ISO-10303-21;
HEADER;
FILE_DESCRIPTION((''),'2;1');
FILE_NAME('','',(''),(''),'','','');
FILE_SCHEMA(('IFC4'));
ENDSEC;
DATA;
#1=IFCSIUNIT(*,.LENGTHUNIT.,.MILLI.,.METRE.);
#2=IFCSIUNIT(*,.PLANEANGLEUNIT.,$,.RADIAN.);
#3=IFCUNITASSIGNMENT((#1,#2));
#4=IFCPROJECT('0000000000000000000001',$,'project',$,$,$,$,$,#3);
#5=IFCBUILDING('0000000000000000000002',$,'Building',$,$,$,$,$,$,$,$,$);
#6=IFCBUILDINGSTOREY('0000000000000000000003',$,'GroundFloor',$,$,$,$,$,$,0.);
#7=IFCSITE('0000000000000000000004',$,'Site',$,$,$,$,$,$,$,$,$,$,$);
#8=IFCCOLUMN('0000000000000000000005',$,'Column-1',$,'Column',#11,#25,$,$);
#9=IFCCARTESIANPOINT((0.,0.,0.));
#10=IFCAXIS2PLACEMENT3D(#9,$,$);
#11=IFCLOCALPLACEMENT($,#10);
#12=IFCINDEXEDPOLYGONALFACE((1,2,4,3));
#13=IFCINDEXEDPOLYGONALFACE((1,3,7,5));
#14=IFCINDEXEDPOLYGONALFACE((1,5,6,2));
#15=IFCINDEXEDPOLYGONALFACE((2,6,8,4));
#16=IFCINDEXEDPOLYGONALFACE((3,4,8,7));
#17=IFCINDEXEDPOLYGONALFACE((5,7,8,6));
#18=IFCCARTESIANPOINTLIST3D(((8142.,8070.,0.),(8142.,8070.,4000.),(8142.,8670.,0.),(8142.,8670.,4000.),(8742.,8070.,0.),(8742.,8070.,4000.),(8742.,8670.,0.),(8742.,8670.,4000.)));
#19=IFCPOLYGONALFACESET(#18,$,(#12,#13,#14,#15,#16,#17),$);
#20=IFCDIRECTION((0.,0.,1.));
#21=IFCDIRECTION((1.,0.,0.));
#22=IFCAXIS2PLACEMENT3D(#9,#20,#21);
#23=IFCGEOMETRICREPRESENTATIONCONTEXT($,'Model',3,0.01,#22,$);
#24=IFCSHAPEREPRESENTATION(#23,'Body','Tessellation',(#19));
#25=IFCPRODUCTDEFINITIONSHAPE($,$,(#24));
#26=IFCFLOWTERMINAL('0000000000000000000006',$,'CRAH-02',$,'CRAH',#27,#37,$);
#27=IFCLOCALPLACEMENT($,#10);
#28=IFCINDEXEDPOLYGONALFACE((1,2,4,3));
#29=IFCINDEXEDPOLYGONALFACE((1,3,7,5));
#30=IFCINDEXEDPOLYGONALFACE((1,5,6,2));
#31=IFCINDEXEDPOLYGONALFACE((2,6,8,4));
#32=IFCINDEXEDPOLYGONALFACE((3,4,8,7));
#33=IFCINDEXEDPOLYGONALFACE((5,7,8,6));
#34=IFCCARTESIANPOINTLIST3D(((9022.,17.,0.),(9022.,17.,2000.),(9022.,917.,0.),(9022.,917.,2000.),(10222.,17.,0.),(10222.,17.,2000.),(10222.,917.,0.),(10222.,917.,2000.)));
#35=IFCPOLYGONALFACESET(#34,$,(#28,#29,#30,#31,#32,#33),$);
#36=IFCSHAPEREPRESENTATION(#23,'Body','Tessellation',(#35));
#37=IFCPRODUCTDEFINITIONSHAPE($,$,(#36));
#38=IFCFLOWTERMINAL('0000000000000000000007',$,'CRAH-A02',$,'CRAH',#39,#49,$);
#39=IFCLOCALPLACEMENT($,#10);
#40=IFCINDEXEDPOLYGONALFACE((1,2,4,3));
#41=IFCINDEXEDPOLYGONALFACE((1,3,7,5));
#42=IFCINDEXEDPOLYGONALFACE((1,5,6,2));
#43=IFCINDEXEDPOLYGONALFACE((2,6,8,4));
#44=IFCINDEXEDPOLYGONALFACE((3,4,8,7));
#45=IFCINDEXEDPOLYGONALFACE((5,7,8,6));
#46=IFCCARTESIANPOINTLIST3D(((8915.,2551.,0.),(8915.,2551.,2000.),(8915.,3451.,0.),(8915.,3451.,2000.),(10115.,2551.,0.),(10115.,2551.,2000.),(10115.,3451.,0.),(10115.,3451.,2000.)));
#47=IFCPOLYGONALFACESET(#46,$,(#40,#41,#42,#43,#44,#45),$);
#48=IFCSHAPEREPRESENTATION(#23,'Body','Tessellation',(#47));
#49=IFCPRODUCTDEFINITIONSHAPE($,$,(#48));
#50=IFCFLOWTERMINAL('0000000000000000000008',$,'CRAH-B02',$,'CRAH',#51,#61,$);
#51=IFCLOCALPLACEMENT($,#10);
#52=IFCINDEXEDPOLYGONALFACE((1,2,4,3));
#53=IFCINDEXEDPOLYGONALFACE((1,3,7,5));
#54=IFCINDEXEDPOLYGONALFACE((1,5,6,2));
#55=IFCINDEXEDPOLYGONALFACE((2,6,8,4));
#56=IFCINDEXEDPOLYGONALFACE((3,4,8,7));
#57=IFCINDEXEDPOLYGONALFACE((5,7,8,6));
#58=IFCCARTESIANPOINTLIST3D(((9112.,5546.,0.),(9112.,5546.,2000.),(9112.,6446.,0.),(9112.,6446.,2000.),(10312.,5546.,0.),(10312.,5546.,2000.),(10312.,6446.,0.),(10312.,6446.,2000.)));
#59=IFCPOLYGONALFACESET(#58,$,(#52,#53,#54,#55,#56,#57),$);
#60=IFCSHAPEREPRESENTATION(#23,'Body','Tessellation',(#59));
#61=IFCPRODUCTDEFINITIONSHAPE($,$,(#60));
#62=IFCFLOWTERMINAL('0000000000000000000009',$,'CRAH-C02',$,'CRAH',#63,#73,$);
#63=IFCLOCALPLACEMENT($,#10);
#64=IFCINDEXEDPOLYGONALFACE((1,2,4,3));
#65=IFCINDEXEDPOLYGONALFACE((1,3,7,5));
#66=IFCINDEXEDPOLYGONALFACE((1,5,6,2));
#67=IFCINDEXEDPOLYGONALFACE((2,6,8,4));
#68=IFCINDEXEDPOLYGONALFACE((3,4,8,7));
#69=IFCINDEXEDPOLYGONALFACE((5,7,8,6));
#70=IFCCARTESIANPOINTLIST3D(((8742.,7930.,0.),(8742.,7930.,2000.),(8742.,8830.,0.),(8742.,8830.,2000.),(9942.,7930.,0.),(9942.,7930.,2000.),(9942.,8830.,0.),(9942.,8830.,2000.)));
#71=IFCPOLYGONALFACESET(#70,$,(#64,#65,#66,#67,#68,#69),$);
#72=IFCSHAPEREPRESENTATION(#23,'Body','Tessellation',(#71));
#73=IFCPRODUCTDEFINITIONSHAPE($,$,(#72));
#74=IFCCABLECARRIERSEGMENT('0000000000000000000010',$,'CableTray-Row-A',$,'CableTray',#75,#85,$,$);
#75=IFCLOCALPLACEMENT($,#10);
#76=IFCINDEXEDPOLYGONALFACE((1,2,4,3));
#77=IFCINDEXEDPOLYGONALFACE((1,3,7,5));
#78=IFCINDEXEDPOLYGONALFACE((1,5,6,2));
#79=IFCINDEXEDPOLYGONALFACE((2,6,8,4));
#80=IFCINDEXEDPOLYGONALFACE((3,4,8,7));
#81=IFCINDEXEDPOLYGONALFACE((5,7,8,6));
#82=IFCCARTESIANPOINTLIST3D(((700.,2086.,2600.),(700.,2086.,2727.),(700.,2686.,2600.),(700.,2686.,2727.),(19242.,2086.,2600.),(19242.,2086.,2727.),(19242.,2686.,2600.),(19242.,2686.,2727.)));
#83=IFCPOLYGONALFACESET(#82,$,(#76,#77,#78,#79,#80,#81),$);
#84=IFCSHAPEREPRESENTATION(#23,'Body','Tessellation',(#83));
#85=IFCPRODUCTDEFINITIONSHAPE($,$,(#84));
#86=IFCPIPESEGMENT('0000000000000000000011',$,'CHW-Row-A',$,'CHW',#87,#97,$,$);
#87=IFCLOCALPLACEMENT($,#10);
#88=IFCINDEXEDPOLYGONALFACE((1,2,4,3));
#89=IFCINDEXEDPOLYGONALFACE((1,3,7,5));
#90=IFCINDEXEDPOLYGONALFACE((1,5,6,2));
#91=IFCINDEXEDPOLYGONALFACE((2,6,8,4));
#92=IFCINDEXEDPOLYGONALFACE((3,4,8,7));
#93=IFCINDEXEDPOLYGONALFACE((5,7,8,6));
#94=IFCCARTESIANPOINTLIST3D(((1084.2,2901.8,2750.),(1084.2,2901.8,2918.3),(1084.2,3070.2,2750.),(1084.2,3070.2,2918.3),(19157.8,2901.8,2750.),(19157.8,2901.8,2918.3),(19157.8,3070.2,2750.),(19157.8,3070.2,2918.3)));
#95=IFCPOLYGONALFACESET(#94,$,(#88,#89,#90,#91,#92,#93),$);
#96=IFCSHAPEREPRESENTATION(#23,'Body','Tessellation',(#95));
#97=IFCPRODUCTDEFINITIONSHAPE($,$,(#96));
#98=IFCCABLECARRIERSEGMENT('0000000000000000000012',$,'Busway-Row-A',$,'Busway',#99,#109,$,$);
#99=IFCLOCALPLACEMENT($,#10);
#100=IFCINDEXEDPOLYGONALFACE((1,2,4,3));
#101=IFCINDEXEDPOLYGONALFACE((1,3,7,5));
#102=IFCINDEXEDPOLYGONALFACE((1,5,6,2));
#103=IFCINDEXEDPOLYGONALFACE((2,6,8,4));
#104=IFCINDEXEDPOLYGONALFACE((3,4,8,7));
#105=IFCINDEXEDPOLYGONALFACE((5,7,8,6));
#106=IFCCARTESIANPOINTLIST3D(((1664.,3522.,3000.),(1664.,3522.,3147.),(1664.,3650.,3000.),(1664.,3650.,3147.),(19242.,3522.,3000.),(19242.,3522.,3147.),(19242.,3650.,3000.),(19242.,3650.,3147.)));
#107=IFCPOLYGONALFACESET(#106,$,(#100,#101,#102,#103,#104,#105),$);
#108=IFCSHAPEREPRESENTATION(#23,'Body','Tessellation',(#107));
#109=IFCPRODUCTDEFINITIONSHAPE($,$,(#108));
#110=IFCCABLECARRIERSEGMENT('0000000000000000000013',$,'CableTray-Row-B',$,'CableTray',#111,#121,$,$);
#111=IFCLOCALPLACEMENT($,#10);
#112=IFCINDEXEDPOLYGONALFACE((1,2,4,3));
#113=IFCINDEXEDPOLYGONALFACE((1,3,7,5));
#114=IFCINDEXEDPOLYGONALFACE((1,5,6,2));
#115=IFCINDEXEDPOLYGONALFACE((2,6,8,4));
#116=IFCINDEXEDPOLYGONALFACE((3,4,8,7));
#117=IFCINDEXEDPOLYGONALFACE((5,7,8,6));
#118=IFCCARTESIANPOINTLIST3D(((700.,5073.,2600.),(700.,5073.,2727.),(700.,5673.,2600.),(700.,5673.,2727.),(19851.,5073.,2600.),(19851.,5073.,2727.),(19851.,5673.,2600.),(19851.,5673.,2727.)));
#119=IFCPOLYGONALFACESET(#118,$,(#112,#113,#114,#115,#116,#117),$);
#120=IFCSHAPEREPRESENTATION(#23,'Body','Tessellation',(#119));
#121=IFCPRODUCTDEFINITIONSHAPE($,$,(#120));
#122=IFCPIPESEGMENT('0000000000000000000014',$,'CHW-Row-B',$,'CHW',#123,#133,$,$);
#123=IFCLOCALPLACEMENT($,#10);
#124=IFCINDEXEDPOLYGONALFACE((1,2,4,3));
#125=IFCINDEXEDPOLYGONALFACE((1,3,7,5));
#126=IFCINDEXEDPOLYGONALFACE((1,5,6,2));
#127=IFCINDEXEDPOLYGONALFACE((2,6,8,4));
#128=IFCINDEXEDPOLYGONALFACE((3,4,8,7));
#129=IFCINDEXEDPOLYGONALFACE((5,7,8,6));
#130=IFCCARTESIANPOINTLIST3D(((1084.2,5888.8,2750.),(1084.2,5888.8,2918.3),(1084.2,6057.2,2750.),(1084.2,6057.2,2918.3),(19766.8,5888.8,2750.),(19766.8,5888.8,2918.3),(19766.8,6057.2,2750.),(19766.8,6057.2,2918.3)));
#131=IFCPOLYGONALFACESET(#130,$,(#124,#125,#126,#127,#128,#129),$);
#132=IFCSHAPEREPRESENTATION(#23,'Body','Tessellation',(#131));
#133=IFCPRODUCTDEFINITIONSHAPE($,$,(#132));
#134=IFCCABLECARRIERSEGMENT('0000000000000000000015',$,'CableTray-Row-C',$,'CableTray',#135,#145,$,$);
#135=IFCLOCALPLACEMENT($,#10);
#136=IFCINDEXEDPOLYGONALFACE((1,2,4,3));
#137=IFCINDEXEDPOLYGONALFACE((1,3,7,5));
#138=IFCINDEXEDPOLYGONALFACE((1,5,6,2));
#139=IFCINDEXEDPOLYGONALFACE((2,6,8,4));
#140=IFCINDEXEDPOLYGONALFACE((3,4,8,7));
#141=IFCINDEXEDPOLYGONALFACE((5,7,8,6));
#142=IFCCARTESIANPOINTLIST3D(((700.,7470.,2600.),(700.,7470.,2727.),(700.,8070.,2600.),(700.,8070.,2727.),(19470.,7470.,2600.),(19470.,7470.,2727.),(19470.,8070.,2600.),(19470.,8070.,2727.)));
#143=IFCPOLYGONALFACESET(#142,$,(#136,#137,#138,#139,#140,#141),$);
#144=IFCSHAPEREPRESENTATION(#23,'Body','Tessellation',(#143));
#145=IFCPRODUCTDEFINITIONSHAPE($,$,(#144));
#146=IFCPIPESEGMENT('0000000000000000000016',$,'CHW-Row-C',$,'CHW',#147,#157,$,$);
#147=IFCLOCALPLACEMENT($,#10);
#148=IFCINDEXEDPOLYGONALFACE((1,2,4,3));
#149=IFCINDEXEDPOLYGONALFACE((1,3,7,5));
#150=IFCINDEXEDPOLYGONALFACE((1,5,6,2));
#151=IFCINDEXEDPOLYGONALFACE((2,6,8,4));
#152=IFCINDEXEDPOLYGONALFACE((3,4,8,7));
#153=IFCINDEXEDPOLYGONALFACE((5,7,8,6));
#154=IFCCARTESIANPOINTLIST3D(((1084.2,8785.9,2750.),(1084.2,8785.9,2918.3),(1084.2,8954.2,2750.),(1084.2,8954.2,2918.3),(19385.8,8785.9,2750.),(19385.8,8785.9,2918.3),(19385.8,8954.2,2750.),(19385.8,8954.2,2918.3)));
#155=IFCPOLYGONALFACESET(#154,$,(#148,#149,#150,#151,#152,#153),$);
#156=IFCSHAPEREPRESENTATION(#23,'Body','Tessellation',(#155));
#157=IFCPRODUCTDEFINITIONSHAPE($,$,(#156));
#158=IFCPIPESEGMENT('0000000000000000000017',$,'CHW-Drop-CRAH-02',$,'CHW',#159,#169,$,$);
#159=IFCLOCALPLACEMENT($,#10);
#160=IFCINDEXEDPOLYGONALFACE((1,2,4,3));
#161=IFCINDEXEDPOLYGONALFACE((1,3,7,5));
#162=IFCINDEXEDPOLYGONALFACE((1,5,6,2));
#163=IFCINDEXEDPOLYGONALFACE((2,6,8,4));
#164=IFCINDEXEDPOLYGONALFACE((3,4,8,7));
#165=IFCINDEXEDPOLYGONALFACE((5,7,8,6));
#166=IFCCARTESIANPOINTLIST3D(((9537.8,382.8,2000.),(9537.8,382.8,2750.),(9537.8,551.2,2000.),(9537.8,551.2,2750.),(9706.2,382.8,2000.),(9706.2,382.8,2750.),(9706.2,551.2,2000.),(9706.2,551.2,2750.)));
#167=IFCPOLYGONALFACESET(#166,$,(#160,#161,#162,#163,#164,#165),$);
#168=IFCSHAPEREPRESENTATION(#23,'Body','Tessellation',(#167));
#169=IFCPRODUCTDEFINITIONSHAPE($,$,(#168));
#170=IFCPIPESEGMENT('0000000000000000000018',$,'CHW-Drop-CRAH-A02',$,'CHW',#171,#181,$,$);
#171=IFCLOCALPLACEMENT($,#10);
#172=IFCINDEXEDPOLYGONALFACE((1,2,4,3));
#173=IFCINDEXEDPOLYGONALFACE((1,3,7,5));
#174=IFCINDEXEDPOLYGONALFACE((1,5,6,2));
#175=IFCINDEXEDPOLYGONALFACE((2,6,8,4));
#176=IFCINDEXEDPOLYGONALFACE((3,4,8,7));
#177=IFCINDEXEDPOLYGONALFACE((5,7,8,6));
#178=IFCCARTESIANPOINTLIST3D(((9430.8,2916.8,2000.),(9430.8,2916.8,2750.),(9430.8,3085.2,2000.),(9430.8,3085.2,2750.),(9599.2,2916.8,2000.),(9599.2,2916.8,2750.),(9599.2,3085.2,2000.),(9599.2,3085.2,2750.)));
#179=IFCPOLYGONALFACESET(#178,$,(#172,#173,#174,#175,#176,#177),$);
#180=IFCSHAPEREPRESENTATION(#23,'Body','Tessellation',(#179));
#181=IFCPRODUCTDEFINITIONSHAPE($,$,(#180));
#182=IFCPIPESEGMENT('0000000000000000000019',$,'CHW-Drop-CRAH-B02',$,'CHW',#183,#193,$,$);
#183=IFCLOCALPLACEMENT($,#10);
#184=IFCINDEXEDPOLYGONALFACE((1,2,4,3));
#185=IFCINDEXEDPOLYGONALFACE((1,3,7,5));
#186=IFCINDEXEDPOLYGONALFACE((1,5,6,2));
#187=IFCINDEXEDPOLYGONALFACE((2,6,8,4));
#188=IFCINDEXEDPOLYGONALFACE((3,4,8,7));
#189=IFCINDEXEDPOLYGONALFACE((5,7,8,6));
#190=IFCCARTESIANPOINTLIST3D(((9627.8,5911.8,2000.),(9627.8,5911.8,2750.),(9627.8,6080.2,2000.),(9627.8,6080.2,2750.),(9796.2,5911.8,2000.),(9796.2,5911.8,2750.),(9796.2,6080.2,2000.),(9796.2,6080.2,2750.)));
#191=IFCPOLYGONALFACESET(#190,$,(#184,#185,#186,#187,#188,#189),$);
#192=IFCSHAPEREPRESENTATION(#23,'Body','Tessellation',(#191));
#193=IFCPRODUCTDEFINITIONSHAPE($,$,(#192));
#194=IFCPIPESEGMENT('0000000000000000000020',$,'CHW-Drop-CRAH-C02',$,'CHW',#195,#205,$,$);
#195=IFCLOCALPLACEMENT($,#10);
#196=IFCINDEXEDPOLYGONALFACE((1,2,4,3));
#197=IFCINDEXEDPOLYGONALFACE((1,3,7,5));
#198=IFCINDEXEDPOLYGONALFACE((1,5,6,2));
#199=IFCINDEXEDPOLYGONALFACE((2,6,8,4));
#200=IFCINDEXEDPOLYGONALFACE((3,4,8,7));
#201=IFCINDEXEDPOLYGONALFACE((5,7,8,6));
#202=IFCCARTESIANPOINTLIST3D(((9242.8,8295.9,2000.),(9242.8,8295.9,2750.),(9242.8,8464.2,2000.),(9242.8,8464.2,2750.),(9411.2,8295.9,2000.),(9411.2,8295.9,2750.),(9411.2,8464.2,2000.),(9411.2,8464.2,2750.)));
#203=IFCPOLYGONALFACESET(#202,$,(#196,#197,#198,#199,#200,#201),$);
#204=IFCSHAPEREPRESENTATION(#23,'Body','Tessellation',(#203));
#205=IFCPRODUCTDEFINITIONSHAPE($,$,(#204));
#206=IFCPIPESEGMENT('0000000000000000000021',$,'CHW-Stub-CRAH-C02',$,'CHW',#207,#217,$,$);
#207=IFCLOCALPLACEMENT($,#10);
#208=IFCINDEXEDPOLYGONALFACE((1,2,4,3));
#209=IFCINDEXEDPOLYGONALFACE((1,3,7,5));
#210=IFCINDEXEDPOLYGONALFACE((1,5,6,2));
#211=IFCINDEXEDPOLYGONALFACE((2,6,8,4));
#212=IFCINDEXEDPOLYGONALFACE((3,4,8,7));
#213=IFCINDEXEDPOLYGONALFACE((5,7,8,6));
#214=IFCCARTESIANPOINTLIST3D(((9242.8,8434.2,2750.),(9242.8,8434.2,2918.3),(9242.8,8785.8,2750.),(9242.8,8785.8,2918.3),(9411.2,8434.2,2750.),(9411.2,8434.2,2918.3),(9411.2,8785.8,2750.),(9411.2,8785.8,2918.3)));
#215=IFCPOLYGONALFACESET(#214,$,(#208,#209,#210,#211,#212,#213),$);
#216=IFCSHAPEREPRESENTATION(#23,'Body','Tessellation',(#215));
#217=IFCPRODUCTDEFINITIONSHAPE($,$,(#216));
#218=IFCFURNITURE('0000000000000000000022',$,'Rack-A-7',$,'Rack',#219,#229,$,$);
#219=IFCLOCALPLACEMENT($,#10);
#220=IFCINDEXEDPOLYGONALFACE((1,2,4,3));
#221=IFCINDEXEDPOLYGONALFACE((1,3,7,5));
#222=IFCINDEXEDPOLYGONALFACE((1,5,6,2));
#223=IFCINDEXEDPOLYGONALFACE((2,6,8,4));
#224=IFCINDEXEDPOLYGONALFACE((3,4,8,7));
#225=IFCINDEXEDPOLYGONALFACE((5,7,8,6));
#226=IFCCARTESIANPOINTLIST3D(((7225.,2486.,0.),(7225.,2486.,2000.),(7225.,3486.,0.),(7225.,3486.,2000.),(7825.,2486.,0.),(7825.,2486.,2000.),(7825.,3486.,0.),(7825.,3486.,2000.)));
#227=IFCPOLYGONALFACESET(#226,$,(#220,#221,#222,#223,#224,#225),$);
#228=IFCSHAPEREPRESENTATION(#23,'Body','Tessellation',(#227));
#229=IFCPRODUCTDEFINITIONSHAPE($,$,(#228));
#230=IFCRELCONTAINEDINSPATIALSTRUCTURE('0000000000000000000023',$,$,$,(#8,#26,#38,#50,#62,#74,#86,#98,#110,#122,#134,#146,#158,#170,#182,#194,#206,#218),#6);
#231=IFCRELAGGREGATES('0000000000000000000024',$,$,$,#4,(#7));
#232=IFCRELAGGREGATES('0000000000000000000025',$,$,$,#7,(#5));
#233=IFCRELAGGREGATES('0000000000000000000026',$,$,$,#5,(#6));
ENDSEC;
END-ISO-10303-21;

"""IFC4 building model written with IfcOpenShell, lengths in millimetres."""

from ifc_helpers import new_model, si_unit, frame, origin, origin_with_axes, origin_2d, place, context, project, spatial, rectangle, extrude, element, save


model = new_model("IFC4")

# Units and contexts
model_context = context("Model", 3, precision=0.01, world=origin_with_axes())
ifc_project = project(units=[si_unit("LENGTHUNIT", "METRE", prefix="MILLI"), si_unit("PLANEANGLEUNIT", "RADIAN")])

# Site, building, storey
site = spatial("IfcSite", under=ifc_project, Name="Site")
building = spatial("IfcBuilding", under=site, Name="Building")
storey = spatial("IfcBuildingStorey", under=building, Name="GroundFloor", Elevation=0.0)

# Column
column_placement = place(None, frame((8442.0, 8370.0, 0.0), z_axis=(0.0, 0.0, 1.0), x_axis=(1.0, 0.0, 0.0)))
element("IfcColumn", 1, at=column_placement, inside=storey, Name="Column-1", ObjectType="Column", context=model_context, shape_type="SweptSolid", body=[
    extrude(rectangle(XDim=600.0, YDim=600.0, at=origin_2d()), origin(), (0.0, 0.0, 1.0), 4000.0),
])

# Flow terminals
for number, where, z_axis, x_axis, name in (
    (2, (9622.0, 467.0, 0.0), (0.0, 0.0, 1.0), (1.0, 0.0, 0.0), "CRAH-02"),
    (3, (9515.0, 3001.0, 0.0), (0.0, 0.0, 1.0), (1.0, 0.0, 0.0), "CRAH-A02"),
    (4, (9712.0, 5996.0, 0.0), (0.0, 0.0, 1.0), (1.0, 0.0, 0.0), "CRAH-B02"),
    (5, (9342.0, 8380.0, 0.0), (0.0, 0.0, 1.0), (1.0, 0.0, 0.0), "CRAH-C02"),
):
    element("IfcFlowTerminal", number, at=place(None, frame(where, z_axis=z_axis, x_axis=x_axis)), inside=storey, Name=name, ObjectType="CRAH", context=model_context, shape_type="SweptSolid", body=[
        extrude(rectangle(XDim=1200.0, YDim=900.0, at=origin_2d()), origin(), (0.0, 0.0, 1.0), 2000.0),
    ])

# Cable carrier segment
cable_carrier_segment_1_placement = place(None, frame((9971.0, 2386.0, 2600.0), z_axis=(0.0, 0.0, 1.0), x_axis=(1.0, 0.0, 0.0)))
element("IfcCableCarrierSegment", 6, at=cable_carrier_segment_1_placement, inside=storey, Name="CableTray-Row-A", ObjectType="CableTray", context=model_context, shape_type="SweptSolid", body=[
    extrude(rectangle(XDim=18542.0, YDim=600.0, at=origin_2d()), origin(), (0.0, 0.0, 1.0), 127.0),
])

# Pipe segment
pipe_segment_1_placement = place(None, frame((10121.0, 2986.0, 2750.0), z_axis=(0.0, 0.0, 1.0), x_axis=(1.0, 0.0, 0.0)))
element("IfcPipeSegment", 7, at=pipe_segment_1_placement, inside=storey, Name="CHW-Row-A", ObjectType="CHW", context=model_context, shape_type="SweptSolid", body=[
    extrude(rectangle(XDim=18073.7, YDim=168.3, at=origin_2d()), origin(), (0.0, 0.0, 1.0), 168.3),
])

# Cable carrier segments
cable_carrier_segment_2_placement = place(None, frame((10453.0, 3586.0, 3000.0), z_axis=(0.0, 0.0, 1.0), x_axis=(1.0, 0.0, 0.0)))
element("IfcCableCarrierSegment", 8, at=cable_carrier_segment_2_placement, inside=storey, Name="Busway-Row-A", ObjectType="Busway", context=model_context, shape_type="SweptSolid", body=[
    extrude(rectangle(XDim=17578.0, YDim=128.0, at=origin_2d()), origin(), (0.0, 0.0, 1.0), 147.0),
])
cable_carrier_segment_3_placement = place(None, frame((10275.5, 5373.0, 2600.0), z_axis=(0.0, 0.0, 1.0), x_axis=(1.0, 0.0, 0.0)))
element("IfcCableCarrierSegment", 9, at=cable_carrier_segment_3_placement, inside=storey, Name="CableTray-Row-B", ObjectType="CableTray", context=model_context, shape_type="SweptSolid", body=[
    extrude(rectangle(XDim=19151.0, YDim=600.0, at=origin_2d()), origin(), (0.0, 0.0, 1.0), 127.0),
])

# Pipe segment
pipe_segment_2_placement = place(None, frame((10425.5, 5973.0, 2750.0), z_axis=(0.0, 0.0, 1.0), x_axis=(1.0, 0.0, 0.0)))
element("IfcPipeSegment", 10, at=pipe_segment_2_placement, inside=storey, Name="CHW-Row-B", ObjectType="CHW", context=model_context, shape_type="SweptSolid", body=[
    extrude(rectangle(XDim=18682.7, YDim=168.3, at=origin_2d()), origin(), (0.0, 0.0, 1.0), 168.3),
])

# Cable carrier segment
cable_carrier_segment_4_placement = place(None, frame((10085.0, 7770.0, 2600.0), z_axis=(0.0, 0.0, 1.0), x_axis=(1.0, 0.0, 0.0)))
element("IfcCableCarrierSegment", 11, at=cable_carrier_segment_4_placement, inside=storey, Name="CableTray-Row-C", ObjectType="CableTray", context=model_context, shape_type="SweptSolid", body=[
    extrude(rectangle(XDim=18770.0, YDim=600.0, at=origin_2d()), origin(), (0.0, 0.0, 1.0), 127.0),
])

# Pipe segments
pipe_segment_3_placement = place(None, frame((10235.0, 8870.0, 2750.0), z_axis=(0.0, 0.0, 1.0), x_axis=(1.0, 0.0, 0.0)))
element("IfcPipeSegment", 12, at=pipe_segment_3_placement, inside=storey, Name="CHW-Row-C", ObjectType="CHW", context=model_context, shape_type="SweptSolid", body=[
    extrude(rectangle(XDim=18301.7, YDim=168.3, at=origin_2d()), origin(), (0.0, 0.0, 1.0), 168.3),
])
for number, where, z_axis, x_axis, name in (
    (13, (9622.0, 467.0, 2000.0), (0.0, 0.0, 1.0), (1.0, 0.0, 0.0), "CHW-Drop-CRAH-02"),
    (14, (9515.0, 3001.0, 2000.0), (0.0, 0.0, 1.0), (1.0, 0.0, 0.0), "CHW-Drop-CRAH-A02"),
    (15, (9712.0, 5996.0, 2000.0), (0.0, 0.0, 1.0), (1.0, 0.0, 0.0), "CHW-Drop-CRAH-B02"),
    (16, (9327.0, 8380.0, 2000.0), (0.0, 0.0, 1.0), (1.0, 0.0, 0.0), "CHW-Drop-CRAH-C02"),
):
    element("IfcPipeSegment", number, at=place(None, frame(where, z_axis=z_axis, x_axis=x_axis)), inside=storey, Name=name, ObjectType="CHW", context=model_context, shape_type="SweptSolid", body=[
        extrude(rectangle(XDim=168.3, YDim=168.3, at=origin_2d()), origin(), (0.0, 0.0, 1.0), 750.0),
    ])
pipe_segment_4_placement = place(None, frame((9327.0, 8610.0, 2750.0), z_axis=(0.0, 0.0, 1.0), x_axis=(1.0, 0.0, 0.0)))
element("IfcPipeSegment", 17, at=pipe_segment_4_placement, inside=storey, Name="CHW-Stub-CRAH-C02", ObjectType="CHW", context=model_context, shape_type="SweptSolid", body=[
    extrude(rectangle(XDim=168.3, YDim=351.7, at=origin_2d()), origin(), (0.0, 0.0, 1.0), 168.3),
])

# Furniture
for number, where, z_axis, x_axis, name in (
    (18, (7525.0, 2986.0, 0.0), (0.0, 0.0, 1.0), (1.0, 0.0, 0.0), "Rack-A-7"),
):
    element("IfcFurniture", number, at=place(None, frame(where, z_axis=z_axis, x_axis=x_axis)), inside=storey, Name=name, ObjectType="Rack", context=model_context, shape_type="SweptSolid", body=[
        extrude(rectangle(XDim=600.0, YDim=1000.0, at=origin_2d()), origin(), (0.0, 0.0, 1.0), 2000.0),
    ])

save(model, "model.ifc")
